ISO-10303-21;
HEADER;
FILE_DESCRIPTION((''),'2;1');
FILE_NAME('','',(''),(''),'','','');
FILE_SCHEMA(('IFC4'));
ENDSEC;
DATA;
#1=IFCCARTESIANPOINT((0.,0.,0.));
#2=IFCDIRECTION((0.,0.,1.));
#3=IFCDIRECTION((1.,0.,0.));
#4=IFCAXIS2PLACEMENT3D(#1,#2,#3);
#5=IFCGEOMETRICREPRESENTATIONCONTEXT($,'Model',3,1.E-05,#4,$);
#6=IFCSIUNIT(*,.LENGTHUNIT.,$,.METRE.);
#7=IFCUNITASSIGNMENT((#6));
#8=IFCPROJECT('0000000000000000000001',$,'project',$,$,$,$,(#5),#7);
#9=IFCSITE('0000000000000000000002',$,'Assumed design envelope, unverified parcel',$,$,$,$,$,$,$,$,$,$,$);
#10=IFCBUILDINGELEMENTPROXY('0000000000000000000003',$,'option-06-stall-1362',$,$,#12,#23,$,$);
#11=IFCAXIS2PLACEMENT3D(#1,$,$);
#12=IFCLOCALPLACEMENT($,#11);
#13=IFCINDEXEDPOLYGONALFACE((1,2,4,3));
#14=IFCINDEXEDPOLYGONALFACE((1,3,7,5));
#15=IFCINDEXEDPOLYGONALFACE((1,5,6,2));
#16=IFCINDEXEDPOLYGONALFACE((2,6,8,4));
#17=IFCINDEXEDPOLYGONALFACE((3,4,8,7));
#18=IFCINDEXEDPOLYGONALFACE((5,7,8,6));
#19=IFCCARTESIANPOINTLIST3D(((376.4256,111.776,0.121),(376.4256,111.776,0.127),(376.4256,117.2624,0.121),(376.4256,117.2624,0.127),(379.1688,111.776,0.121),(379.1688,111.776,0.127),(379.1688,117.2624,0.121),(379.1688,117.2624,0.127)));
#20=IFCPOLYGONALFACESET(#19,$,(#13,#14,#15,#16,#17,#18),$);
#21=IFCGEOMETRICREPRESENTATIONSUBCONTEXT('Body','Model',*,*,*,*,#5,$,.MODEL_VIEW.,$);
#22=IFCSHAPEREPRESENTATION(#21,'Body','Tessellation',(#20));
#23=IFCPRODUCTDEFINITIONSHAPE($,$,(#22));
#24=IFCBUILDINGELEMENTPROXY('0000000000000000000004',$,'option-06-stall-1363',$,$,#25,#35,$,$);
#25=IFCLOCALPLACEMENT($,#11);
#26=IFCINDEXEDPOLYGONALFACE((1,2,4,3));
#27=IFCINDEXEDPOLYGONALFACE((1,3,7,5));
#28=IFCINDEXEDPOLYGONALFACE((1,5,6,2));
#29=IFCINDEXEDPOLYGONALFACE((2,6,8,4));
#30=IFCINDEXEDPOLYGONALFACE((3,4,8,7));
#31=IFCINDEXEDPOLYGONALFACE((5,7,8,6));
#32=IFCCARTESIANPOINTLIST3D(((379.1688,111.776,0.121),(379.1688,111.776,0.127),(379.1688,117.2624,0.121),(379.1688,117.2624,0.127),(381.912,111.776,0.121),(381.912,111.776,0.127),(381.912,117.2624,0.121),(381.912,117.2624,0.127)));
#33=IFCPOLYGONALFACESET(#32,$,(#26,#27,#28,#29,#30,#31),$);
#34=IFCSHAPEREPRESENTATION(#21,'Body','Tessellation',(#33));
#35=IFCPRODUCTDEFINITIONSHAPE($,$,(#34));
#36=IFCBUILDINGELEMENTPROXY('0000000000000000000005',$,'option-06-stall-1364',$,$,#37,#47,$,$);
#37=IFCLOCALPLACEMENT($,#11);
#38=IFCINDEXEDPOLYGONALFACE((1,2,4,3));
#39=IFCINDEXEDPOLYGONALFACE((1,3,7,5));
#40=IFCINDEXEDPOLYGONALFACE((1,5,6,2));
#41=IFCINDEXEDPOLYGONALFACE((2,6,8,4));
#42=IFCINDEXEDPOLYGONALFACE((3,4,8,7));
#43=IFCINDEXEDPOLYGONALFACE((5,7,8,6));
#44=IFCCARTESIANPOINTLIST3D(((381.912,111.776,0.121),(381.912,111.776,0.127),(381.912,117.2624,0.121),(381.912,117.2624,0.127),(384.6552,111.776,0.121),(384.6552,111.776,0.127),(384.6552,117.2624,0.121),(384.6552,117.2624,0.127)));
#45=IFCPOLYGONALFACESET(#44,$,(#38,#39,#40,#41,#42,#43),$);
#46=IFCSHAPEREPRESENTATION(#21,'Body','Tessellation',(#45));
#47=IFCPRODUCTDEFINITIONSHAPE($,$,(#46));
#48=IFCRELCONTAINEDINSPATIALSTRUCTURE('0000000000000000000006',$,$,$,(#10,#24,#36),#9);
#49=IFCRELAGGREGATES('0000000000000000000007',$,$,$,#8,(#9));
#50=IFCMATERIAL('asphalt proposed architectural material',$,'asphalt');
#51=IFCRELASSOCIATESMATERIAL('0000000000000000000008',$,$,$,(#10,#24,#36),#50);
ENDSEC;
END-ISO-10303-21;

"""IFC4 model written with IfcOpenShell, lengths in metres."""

from ifc_helpers import new_model, si_unit, frame, origin_with_axes, place, context, subcontext, project, spatial, rectangle, extrude, material, element, save


model = new_model("IFC4")

# Units and contexts
model_context = context("Model", 3, precision=1e-05, world=origin_with_axes())
body_context = subcontext(model_context, "Body", "Model", "MODEL_VIEW")
ifc_project = project(units=[si_unit("LENGTHUNIT", "METRE")], contexts=[model_context])

# Site
site = spatial("IfcSite", under=ifc_project, Name="Assumed design envelope, unverified parcel")

# Building element proxies
ifc_material = material(Name="asphalt proposed architectural material", Category="asphalt")
for number, where, z_axis, x_axis, name in (
    (1, (377.7972, 114.5192, 0.121), (0.0, 0.0, 1.0), (1.0, 0.0, 0.0), "option-06-stall-1362"),
    (2, (380.5404, 114.5192, 0.121), (0.0, 0.0, 1.0), (1.0, 0.0, 0.0), "option-06-stall-1363"),
    (3, (383.2836, 114.5192, 0.121), (0.0, 0.0, 1.0), (1.0, 0.0, 0.0), "option-06-stall-1364"),
):
    element("IfcBuildingElementProxy", number, at=place(None, frame(where, z_axis=z_axis, x_axis=x_axis)), inside=site, material=ifc_material, Name=name, context=body_context, shape_type="SweptSolid", body=[
        extrude(rectangle(XDim=2.7432, YDim=5.4864), origin_with_axes(), (0.0, 0.0, 1.0), 0.006),
    ])

save(model, "model.ifc")
